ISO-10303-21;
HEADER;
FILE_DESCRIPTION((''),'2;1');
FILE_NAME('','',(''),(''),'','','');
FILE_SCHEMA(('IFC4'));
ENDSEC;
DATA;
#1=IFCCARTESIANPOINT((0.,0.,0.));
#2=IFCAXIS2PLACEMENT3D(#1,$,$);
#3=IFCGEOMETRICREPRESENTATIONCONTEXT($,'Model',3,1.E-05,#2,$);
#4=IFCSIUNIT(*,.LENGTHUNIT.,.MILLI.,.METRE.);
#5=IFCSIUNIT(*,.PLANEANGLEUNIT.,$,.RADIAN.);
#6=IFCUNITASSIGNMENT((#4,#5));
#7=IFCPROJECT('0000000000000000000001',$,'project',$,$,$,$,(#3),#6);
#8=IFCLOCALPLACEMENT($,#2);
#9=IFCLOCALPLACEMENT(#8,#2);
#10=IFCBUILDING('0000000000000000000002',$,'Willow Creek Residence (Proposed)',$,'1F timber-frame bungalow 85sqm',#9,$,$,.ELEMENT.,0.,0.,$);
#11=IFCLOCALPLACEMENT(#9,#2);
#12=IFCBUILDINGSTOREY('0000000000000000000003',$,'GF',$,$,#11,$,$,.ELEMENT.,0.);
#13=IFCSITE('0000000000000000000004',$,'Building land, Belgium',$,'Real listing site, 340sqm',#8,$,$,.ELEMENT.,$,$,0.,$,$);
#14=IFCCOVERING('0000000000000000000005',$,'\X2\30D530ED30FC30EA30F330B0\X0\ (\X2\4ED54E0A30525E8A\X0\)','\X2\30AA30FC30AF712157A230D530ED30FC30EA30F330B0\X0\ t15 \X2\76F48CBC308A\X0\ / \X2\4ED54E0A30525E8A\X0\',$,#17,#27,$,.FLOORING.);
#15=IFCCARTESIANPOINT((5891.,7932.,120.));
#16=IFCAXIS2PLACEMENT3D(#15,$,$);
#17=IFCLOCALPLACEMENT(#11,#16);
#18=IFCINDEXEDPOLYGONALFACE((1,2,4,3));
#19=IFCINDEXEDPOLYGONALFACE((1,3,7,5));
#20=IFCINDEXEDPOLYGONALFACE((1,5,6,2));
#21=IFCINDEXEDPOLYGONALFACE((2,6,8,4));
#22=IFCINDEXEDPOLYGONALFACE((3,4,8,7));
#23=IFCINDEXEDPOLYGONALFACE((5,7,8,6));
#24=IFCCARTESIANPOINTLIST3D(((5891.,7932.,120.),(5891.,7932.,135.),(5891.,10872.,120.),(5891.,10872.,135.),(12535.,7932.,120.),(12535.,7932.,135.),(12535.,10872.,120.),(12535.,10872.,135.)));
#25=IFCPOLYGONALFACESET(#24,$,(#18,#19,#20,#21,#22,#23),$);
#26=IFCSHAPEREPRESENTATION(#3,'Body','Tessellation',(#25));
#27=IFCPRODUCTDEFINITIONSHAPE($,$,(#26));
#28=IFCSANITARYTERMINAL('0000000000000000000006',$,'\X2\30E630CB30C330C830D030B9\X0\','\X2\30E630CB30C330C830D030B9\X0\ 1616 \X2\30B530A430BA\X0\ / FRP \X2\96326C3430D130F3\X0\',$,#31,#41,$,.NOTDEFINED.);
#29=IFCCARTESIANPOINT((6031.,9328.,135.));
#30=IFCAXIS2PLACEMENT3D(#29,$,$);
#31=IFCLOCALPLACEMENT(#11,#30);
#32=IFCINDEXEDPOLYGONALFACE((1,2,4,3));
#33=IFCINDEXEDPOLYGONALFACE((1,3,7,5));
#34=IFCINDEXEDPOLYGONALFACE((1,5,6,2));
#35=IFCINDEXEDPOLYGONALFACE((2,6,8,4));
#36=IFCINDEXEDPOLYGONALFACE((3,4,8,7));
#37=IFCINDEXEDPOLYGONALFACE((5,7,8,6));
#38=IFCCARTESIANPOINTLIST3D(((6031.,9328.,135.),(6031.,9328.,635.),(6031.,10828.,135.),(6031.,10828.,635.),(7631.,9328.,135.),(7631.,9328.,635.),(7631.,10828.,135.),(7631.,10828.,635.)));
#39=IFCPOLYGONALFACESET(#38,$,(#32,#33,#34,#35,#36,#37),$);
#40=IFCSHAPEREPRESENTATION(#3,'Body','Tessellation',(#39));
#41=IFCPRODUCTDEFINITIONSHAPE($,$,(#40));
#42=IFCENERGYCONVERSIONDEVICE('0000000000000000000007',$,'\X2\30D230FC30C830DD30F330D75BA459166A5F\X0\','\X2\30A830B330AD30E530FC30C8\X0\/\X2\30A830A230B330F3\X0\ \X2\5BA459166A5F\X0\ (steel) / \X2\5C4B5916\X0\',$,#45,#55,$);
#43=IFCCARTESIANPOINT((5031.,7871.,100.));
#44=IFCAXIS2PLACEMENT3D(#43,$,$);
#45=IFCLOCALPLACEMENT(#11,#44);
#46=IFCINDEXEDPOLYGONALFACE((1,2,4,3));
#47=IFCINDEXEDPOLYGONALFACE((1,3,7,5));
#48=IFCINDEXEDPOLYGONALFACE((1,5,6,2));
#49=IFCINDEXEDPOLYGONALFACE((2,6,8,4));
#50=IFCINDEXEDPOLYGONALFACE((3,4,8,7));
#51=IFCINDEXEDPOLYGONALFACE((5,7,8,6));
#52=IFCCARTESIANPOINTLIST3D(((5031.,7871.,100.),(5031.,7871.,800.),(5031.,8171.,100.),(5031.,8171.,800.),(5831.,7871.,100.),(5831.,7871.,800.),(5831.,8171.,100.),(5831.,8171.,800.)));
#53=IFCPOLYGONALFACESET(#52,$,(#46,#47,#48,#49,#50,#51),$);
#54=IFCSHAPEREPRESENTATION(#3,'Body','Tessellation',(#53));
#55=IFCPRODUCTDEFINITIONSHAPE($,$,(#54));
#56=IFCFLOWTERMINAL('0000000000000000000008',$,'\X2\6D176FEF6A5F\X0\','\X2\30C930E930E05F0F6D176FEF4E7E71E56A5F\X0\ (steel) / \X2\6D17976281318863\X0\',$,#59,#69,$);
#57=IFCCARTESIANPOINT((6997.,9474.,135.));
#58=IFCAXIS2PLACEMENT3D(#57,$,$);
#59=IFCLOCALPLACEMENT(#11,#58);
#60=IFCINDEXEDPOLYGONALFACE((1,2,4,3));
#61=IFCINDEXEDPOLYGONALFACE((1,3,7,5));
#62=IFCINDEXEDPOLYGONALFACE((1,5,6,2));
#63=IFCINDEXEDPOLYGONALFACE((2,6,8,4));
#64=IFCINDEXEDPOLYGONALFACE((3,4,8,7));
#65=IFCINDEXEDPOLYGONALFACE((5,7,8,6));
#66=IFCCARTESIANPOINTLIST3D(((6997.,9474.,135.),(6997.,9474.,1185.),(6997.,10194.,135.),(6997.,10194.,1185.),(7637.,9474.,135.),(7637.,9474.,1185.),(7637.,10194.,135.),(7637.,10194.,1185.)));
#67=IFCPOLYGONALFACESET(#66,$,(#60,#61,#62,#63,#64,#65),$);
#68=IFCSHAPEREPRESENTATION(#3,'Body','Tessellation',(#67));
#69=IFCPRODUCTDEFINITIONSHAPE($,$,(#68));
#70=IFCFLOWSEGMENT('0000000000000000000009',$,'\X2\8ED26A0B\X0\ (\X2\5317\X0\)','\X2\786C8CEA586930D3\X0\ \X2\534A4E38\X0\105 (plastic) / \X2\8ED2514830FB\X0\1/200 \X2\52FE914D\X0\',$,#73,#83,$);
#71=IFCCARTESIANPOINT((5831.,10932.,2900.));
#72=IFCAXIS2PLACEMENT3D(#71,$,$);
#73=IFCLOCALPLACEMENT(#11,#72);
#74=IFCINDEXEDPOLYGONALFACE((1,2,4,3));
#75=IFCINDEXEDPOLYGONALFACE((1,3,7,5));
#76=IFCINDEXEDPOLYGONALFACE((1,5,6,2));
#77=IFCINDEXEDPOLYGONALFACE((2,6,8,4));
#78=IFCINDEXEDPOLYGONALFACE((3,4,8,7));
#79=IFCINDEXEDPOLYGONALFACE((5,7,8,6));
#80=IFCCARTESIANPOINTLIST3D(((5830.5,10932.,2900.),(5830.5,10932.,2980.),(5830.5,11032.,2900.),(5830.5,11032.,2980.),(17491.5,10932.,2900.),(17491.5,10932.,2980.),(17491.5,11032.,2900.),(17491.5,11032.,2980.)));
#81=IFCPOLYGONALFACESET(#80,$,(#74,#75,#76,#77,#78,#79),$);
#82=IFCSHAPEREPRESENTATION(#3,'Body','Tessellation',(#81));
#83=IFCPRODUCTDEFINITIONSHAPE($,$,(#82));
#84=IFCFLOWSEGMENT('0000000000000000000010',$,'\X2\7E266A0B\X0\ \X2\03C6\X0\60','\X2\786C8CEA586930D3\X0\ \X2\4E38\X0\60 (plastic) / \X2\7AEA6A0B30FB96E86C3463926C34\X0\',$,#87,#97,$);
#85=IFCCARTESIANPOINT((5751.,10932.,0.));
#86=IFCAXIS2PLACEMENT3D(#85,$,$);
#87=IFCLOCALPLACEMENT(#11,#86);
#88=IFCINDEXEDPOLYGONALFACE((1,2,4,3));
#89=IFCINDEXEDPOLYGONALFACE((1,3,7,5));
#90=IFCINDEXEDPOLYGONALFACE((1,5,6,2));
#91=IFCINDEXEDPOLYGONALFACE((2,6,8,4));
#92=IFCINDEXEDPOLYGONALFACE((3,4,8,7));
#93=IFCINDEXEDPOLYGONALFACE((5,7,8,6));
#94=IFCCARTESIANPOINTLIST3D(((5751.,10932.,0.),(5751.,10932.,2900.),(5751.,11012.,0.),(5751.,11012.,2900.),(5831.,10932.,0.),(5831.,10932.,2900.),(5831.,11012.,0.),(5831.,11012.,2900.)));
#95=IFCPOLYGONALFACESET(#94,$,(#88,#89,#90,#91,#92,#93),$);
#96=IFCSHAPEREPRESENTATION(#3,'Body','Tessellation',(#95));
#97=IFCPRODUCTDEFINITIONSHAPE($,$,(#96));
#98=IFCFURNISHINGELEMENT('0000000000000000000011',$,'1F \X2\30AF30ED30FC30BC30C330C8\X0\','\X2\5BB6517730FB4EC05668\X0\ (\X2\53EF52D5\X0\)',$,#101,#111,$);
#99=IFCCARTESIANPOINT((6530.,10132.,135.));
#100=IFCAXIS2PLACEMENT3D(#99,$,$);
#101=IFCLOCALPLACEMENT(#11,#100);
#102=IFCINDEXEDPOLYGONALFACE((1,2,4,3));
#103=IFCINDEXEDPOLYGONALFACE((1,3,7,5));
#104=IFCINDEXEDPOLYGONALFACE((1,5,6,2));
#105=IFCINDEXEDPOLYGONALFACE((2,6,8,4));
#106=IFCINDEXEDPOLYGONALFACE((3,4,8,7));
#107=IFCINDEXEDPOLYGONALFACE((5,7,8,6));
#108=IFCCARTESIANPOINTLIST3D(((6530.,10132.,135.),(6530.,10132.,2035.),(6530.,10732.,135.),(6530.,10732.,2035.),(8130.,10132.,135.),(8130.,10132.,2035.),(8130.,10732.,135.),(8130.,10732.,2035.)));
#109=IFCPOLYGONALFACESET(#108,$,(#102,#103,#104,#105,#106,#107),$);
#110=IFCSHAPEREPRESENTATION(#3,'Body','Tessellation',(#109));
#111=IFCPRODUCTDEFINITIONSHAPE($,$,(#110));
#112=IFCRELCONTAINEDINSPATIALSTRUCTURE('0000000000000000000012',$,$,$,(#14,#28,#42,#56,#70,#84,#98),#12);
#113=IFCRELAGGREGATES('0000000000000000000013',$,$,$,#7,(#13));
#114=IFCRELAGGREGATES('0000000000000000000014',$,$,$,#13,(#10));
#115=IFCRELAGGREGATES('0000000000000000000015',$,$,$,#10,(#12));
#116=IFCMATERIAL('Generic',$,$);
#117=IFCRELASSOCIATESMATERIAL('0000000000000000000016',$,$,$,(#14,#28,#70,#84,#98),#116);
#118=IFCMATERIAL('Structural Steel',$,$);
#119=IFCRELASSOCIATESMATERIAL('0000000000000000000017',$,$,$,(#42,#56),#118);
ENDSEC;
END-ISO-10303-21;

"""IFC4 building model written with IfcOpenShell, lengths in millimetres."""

from ifc_helpers import new_model, si_unit, frame, frame_2d, origin, place, context, project, spatial, rectangle, extrude, material, element, save


model = new_model("IFC4")

# Units and contexts
model_context = context("Model", 3, precision=1e-05, world=origin())
ifc_project = project(units=[si_unit("LENGTHUNIT", "METRE", prefix="MILLI"), si_unit("PLANEANGLEUNIT", "RADIAN")], contexts=[model_context])

# Site, building, storey
site_placement = place(None, origin())
site = spatial("IfcSite", under=ifc_project, at=site_placement, Name="Building land, Belgium", ObjectType="Real listing site, 340sqm", CompositionType="ELEMENT", RefElevation=0.0)
building_placement = place(site_placement, origin())
building = spatial("IfcBuilding", under=site, at=building_placement, Name="Willow Creek Residence (Proposed)", ObjectType="1F timber-frame bungalow 85sqm", CompositionType="ELEMENT", ElevationOfRefHeight=0.0, ElevationOfTerrain=0.0)
storey_placement = place(building_placement, origin())
storey = spatial("IfcBuildingStorey", under=building, at=storey_placement, Name="GF", CompositionType="ELEMENT", Elevation=0.0)

# Shared definitions
ifc_material_1 = material(Name="Structural Steel")

# Covering
ifc_material_2 = material(Name="Generic")
covering_placement = place(storey_placement, frame((5891.0, 7932.0, 120.0)))
element("IfcCovering", 1, at=covering_placement, inside=storey, material=ifc_material_2, Name="フローリング (仕上げ床)", Description="オーク無垢フローリング t15 直貼り / 仕上げ床", PredefinedType="FLOORING", context=model_context, shape_type="SweptSolid", body=[
    extrude(rectangle(XDim=6644.0, YDim=2940.0, at=frame_2d((3322.0, 1470.0))), frame((5891.0, 7932.0, 120.0)), (0.0, 0.0, 1.0), 15.0),
])

# Sanitary terminal
sanitary_terminal_placement = place(storey_placement, frame((6031.0, 9328.0, 135.0)))
element("IfcSanitaryTerminal", 2, at=sanitary_terminal_placement, inside=storey, material=ifc_material_2, Name="ユニットバス", Description="ユニットバス 1616 サイズ / FRP 防水パン", PredefinedType="NOTDEFINED", context=model_context, shape_type="SweptSolid", body=[
    extrude(rectangle(XDim=1600.0, YDim=1500.0, at=frame_2d((800.0, 750.0))), frame((6031.0, 9328.0, 135.0)), (0.0, 0.0, 1.0), 500.0),
])

# Energy conversion device
energy_conversion_device_placement = place(storey_placement, frame((5031.0, 7871.0, 100.0)))
element("IfcEnergyConversionDevice", 3, at=energy_conversion_device_placement, inside=storey, material=ifc_material_1, Name="ヒートポンプ室外機", Description="エコキュート/エアコン 室外機 (steel) / 屋外", context=model_context, shape_type="SweptSolid", body=[
    extrude(rectangle(XDim=800.0, YDim=300.0, at=frame_2d((400.0, 150.0))), frame((5031.0, 7871.0, 100.0)), (0.0, 0.0, 1.0), 700.0),
])

# Flow terminal
flow_terminal_placement = place(storey_placement, frame((6997.0, 9474.0, 135.0)))
element("IfcFlowTerminal", 4, at=flow_terminal_placement, inside=storey, material=ifc_material_1, Name="洗濯機", Description="ドラム式洗濯乾燥機 (steel) / 洗面脱衣", context=model_context, shape_type="SweptSolid", body=[
    extrude(rectangle(XDim=640.0, YDim=720.0, at=frame_2d((320.0, 360.0))), frame((6997.0, 9474.0, 135.0)), (0.0, 0.0, 1.0), 1050.0),
])

# Flow segments
flow_segment_1_placement = place(storey_placement, frame((5831.0, 10932.0, 2900.0)))
element("IfcFlowSegment", 5, at=flow_segment_1_placement, inside=storey, material=ifc_material_2, Name="軒樋 (北)", Description="硬質塩ビ 半丸105 (plastic) / 軒先・1/200 勾配", context=model_context, shape_type="SweptSolid", body=[
    extrude(rectangle(XDim=11661.0, YDim=100.0, at=frame_2d((5830.0, 50.0))), frame((5831.0, 10932.0, 2900.0)), (0.0, 0.0, 1.0), 80.0),
])
flow_segment_2_placement = place(storey_placement, frame((5751.0, 10932.0, 0.0)))
element("IfcFlowSegment", 6, at=flow_segment_2_placement, inside=storey, material=ifc_material_2, Name="縦樋 φ60", Description="硬質塩ビ 丸60 (plastic) / 竪樋・雨水排水", context=model_context, shape_type="SweptSolid", body=[
    extrude(rectangle(XDim=80.0, YDim=80.0, at=frame_2d((40.0, 40.0))), frame((5751.0, 10932.0, 0.0)), (0.0, 0.0, 1.0), 2900.0),
])

# Furnishing element
furnishing_placement = place(storey_placement, frame((6530.0, 10132.0, 135.0)))
element("IfcFurnishingElement", 7, at=furnishing_placement, inside=storey, material=ifc_material_2, Name="1F クローゼット", Description="家具・什器 (可動)", context=model_context, shape_type="SweptSolid", body=[
    extrude(rectangle(XDim=1600.0, YDim=600.0, at=frame_2d((800.0, 300.0))), frame((6530.0, 10132.0, 135.0)), (0.0, 0.0, 1.0), 1900.0),
])

save(model, "model.ifc")
